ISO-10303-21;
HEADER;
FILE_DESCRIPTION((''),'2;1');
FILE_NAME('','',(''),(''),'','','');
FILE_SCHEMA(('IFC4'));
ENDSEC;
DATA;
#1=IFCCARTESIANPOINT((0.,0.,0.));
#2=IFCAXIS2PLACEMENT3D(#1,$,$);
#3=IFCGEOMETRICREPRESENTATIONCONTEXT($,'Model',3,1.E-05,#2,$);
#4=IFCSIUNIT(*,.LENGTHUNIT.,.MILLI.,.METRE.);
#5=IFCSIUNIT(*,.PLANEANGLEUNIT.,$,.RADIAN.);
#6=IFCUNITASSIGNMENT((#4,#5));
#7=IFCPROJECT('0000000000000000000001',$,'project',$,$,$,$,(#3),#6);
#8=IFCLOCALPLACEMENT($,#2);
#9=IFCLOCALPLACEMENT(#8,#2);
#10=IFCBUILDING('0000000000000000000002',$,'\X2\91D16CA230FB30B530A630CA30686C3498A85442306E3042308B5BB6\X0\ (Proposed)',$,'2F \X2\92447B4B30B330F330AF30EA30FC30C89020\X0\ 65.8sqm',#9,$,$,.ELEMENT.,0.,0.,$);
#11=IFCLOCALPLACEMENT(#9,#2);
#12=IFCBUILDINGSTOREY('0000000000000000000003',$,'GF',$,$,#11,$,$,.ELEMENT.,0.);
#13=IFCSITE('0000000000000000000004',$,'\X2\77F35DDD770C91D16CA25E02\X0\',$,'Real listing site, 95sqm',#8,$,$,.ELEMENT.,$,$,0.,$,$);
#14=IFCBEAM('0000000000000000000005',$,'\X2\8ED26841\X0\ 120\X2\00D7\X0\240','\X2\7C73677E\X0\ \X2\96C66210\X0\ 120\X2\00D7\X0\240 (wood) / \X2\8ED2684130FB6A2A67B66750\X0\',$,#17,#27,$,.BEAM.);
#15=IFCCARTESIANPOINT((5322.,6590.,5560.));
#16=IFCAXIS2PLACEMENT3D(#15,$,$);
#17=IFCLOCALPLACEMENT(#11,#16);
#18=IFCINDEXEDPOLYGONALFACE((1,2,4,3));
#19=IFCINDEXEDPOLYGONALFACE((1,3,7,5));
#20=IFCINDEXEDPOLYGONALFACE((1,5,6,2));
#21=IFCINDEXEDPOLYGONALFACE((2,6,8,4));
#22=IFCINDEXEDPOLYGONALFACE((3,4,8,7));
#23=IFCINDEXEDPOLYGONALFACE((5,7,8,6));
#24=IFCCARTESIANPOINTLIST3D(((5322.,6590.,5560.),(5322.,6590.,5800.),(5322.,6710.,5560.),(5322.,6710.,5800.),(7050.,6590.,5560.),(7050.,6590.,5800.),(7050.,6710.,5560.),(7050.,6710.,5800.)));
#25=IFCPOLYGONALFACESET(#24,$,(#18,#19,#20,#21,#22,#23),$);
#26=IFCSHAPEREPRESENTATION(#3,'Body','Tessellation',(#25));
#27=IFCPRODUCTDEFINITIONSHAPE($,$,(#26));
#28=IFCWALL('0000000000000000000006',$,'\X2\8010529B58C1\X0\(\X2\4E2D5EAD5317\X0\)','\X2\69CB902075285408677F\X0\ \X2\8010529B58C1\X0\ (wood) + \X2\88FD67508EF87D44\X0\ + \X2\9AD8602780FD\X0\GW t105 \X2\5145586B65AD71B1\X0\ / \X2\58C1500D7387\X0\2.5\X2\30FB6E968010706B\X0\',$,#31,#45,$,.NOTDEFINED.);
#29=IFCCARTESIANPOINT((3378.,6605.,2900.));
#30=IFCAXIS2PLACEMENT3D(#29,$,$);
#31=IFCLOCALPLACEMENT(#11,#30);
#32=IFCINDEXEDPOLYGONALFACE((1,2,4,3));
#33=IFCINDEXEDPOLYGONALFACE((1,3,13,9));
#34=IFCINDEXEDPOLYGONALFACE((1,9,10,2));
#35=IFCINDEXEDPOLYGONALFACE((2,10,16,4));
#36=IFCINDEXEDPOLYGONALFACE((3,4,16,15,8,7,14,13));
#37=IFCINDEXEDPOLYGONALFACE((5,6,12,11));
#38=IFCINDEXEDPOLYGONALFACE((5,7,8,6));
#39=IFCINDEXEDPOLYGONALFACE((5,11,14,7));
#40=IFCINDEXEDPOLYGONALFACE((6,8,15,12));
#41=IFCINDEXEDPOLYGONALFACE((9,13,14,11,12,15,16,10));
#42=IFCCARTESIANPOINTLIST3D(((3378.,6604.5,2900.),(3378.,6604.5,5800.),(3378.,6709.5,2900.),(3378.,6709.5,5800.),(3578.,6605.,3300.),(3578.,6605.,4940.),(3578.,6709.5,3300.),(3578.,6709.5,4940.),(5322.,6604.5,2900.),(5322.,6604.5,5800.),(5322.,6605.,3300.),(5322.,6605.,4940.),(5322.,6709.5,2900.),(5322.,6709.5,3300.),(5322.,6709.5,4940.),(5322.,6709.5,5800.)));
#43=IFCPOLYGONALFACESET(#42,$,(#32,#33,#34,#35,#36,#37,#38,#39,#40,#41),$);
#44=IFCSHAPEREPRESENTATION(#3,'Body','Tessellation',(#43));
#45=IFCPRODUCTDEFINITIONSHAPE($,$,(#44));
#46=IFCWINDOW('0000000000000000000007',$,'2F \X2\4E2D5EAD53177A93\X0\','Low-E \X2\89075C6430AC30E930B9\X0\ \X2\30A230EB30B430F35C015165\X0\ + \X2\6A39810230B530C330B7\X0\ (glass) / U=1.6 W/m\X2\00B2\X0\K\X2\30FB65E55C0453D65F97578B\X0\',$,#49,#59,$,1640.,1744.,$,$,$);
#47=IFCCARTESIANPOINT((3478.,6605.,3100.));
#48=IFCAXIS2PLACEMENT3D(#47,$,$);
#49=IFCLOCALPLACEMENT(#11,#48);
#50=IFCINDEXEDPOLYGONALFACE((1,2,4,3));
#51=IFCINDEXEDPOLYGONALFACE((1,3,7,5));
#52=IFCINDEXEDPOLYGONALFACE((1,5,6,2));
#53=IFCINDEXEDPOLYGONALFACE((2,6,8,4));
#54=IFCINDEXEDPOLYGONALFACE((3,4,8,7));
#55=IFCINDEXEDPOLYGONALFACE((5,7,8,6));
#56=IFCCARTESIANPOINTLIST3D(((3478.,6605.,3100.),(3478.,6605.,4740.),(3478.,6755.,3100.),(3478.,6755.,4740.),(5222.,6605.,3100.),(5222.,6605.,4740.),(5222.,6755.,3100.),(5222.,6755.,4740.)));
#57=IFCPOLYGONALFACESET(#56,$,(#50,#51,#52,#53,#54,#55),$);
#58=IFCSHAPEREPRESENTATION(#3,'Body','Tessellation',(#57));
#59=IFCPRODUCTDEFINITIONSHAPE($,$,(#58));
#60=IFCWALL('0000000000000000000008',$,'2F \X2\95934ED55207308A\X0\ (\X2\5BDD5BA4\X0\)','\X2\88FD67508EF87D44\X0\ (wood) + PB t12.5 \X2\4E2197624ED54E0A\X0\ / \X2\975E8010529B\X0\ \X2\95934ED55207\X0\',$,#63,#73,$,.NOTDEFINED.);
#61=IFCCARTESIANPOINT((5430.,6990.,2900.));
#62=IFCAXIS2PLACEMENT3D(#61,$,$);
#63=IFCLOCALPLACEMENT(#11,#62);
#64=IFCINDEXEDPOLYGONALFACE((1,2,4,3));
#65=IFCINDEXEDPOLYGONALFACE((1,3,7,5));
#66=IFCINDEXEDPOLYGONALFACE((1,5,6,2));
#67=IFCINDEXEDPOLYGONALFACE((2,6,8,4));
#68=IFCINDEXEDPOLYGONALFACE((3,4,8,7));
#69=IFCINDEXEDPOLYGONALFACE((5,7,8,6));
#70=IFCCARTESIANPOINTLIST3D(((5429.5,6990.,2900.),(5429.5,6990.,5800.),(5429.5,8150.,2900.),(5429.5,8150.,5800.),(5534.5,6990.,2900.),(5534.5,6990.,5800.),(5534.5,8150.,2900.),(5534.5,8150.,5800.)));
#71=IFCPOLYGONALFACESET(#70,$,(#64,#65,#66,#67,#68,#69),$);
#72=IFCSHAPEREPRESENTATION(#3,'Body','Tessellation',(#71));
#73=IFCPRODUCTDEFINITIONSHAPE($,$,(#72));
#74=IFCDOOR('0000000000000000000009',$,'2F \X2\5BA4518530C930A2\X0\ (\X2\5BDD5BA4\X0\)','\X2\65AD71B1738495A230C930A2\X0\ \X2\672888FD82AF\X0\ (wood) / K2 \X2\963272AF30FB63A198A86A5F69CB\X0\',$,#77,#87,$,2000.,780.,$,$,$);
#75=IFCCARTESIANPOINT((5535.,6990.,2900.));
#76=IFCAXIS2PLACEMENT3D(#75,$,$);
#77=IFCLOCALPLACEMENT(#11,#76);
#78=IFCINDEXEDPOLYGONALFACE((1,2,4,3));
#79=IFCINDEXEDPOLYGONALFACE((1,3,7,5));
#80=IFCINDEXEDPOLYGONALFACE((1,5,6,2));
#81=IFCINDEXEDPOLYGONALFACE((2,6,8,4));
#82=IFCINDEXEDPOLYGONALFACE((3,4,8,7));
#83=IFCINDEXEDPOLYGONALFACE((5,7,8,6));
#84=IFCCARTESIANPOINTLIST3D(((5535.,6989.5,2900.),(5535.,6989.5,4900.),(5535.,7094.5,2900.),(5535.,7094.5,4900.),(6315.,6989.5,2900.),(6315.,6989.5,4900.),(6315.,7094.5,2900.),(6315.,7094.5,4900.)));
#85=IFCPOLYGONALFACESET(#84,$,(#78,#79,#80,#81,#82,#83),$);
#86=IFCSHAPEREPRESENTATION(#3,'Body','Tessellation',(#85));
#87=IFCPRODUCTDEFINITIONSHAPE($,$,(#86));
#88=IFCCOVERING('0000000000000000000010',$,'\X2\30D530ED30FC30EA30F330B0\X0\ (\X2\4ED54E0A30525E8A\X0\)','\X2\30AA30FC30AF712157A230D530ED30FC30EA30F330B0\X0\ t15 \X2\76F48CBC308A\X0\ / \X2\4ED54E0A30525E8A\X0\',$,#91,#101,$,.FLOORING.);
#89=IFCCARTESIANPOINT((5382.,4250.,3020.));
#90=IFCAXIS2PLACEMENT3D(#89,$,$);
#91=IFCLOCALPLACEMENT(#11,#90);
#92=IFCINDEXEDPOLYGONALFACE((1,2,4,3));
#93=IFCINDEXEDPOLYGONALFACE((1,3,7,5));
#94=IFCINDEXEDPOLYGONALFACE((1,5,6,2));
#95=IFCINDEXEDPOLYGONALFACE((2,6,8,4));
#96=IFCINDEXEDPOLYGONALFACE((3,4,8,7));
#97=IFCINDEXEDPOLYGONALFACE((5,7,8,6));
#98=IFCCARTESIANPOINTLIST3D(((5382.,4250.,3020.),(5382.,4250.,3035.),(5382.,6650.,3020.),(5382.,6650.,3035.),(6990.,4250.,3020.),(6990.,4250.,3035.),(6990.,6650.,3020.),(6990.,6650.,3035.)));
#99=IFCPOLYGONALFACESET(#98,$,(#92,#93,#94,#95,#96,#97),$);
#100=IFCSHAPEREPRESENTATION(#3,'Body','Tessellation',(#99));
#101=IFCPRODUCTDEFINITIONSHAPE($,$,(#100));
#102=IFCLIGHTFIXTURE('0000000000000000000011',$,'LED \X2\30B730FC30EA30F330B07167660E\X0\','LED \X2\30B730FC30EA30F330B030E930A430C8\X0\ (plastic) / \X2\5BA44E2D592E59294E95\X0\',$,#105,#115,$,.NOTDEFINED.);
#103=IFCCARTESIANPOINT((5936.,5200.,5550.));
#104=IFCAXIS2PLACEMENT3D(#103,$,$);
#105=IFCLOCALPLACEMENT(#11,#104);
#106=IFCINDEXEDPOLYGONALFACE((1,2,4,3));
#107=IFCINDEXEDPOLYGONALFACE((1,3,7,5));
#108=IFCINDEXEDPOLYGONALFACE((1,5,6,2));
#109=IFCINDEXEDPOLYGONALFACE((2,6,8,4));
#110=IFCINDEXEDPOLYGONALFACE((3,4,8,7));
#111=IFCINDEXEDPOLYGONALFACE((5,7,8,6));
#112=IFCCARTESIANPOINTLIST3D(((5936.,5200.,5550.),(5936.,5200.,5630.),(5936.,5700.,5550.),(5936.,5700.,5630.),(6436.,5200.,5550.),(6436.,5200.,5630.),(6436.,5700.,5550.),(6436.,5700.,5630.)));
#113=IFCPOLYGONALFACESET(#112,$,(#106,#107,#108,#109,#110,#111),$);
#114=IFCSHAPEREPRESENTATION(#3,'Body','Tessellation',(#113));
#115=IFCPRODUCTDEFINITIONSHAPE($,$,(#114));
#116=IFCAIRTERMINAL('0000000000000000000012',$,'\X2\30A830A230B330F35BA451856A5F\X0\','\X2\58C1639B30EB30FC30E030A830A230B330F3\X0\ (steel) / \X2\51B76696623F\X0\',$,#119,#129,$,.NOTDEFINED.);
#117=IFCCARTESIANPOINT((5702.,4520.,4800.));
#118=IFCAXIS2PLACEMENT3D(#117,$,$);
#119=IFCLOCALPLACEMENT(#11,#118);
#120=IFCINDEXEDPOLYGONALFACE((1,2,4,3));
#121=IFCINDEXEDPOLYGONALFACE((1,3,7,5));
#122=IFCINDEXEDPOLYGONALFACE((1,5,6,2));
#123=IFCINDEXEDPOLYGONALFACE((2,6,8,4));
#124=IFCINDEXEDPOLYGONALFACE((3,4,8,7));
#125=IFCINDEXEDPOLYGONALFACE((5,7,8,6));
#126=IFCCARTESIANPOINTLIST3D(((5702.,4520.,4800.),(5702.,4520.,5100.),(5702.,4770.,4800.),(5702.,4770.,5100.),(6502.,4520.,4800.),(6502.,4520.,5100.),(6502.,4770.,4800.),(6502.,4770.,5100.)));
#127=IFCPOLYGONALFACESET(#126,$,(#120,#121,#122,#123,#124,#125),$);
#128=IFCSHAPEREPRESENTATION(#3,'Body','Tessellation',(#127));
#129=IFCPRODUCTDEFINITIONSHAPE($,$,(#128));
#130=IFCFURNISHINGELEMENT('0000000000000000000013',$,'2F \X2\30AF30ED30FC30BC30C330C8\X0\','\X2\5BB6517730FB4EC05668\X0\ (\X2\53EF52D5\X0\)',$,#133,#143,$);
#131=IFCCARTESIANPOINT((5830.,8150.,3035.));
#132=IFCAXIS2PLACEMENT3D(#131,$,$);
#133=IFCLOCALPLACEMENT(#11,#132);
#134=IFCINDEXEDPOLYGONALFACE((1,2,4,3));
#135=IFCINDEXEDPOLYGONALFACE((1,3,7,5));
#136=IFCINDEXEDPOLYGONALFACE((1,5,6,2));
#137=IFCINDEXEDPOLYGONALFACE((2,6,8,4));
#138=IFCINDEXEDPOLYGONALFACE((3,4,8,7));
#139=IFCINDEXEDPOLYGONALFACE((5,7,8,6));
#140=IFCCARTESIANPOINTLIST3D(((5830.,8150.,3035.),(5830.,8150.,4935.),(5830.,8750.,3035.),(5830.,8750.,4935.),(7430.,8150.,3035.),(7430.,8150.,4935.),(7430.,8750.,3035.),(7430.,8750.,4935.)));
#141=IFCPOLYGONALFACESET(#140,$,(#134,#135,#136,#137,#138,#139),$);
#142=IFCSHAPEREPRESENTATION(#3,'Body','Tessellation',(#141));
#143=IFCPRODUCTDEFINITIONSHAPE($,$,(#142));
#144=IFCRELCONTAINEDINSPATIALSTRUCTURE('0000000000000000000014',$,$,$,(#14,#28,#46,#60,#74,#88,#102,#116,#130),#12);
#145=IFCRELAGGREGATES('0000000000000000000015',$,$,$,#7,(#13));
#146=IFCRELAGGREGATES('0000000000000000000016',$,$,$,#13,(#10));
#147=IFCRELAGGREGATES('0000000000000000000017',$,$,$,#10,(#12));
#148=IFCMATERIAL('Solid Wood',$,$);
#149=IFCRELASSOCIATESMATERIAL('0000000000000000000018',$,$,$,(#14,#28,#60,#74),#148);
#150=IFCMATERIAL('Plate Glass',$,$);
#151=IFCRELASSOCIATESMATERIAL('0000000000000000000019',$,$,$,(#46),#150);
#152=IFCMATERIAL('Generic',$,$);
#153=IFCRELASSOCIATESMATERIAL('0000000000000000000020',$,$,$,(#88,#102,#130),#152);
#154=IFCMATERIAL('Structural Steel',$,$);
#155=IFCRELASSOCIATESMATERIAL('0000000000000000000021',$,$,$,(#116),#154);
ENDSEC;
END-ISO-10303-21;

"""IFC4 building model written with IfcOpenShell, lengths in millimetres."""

from ifc_helpers import new_model, si_unit, frame, frame_2d, origin, place, context, project, spatial, rectangle, extrude, material, element, fill, save


model = new_model("IFC4")

# Units and contexts
model_context = context("Model", 3, precision=1e-05, world=origin())
ifc_project = project(units=[si_unit("LENGTHUNIT", "METRE", prefix="MILLI"), si_unit("PLANEANGLEUNIT", "RADIAN")], contexts=[model_context])

# Site, building, storey
site_placement = place(None, origin())
site = spatial("IfcSite", under=ifc_project, at=site_placement, Name="石川県金沢市", ObjectType="Real listing site, 95sqm", CompositionType="ELEMENT", RefElevation=0.0)
building_placement = place(site_placement, origin())
building = spatial("IfcBuilding", under=site, at=building_placement, Name="金沢・サウナと水風呂のある家 (Proposed)", ObjectType="2F 鉄筋コンクリート造 65.8sqm", CompositionType="ELEMENT", ElevationOfRefHeight=0.0, ElevationOfTerrain=0.0)
storey_placement = place(building_placement, origin())
storey = spatial("IfcBuildingStorey", under=building, at=storey_placement, Name="GF", CompositionType="ELEMENT", Elevation=0.0)

# Shared definitions
ifc_material_1 = material(Name="Solid Wood")

# Beam
beam_1_placement = place(storey_placement, frame((5322.0, 6590.0, 5560.0)))
element("IfcBeam", 1, at=beam_1_placement, inside=storey, material=ifc_material_1, Name="軒桁 120×240", Description="米松 集成 120×240 (wood) / 軒桁・横架材", PredefinedType="BEAM", context=model_context, shape_type="SweptSolid", body=[
    extrude(rectangle(XDim=1728.0, YDim=120.0, at=frame_2d((864.0, 60.0))), frame((5322.0, 6590.0, 5560.0)), (0.0, 0.0, 1.0), 240.0),
])

# Wall, opening, window
wall_1_placement = place(storey_placement, frame((3378.0, 6605.0, 2900.0)))
wall_1 = element("IfcWall", 2, at=wall_1_placement, inside=storey, material=ifc_material_1, Name="耐力壁(中庭北)", Description="構造用合板 耐力壁 (wood) + 製材軸組 + 高性能GW t105 充填断熱 / 壁倍率2.5・準耐火", PredefinedType="NOTDEFINED", context=model_context, shape_type="SweptSolid", body=[
    extrude(rectangle(XDim=1944.0, YDim=105.0, at=frame_2d((972.0, 52.0))), frame((3378.0, 6605.0, 2900.0)), (0.0, 0.0, 1.0), 2900.0),
])
opening_placement = place(storey_placement, frame((3478.0, 6605.0, 3100.0)))
opening = element("IfcOpeningElement", 3, at=opening_placement, cuts=wall_1, PredefinedType="NOTDEFINED", context=model_context, shape_type="SweptSolid", body=[
    extrude(rectangle(XDim=1744.0, YDim=150.0, at=frame_2d((872.0, 75.0))), frame((3478.0, 6605.0, 3100.0)), (0.0, 0.0, 1.0), 1640.0),
])
ifc_material_2 = material(Name="Plate Glass")
window_placement = place(storey_placement, frame((3478.0, 6605.0, 3100.0)))
window = element("IfcWindow", 4, at=window_placement, inside=storey, material=ifc_material_2, Name="2F 中庭北窓", Description="Low-E 複層ガラス アルゴン封入 + 樹脂サッシ (glass) / U=1.6 W/m²K・日射取得型", OverallHeight=1640.0, OverallWidth=1744.0, context=model_context, shape_type="SweptSolid", body=[
    extrude(rectangle(XDim=1744.0, YDim=150.0, at=frame_2d((872.0, 75.0))), frame((3478.0, 6605.0, 3100.0)), (0.0, 0.0, 1.0), 1640.0),
])
fill(opening, window)

# Wall
wall_2_placement = place(storey_placement, frame((5430.0, 6990.0, 2900.0)))
element("IfcWall", 5, at=wall_2_placement, inside=storey, material=ifc_material_1, Name="2F 間仕切り (寝室)", Description="製材軸組 (wood) + PB t12.5 両面仕上 / 非耐力 間仕切", PredefinedType="NOTDEFINED", context=model_context, shape_type="SweptSolid", body=[
    extrude(rectangle(XDim=105.0, YDim=1160.0, at=frame_2d((52.0, 580.0))), frame((5430.0, 6990.0, 2900.0)), (0.0, 0.0, 1.0), 2900.0),
])

# Door
door_placement = place(storey_placement, frame((5535.0, 6990.0, 2900.0)))
element("IfcDoor", 6, at=door_placement, inside=storey, material=ifc_material_1, Name="2F 室内ドア (寝室)", Description="断熱玄関ドア 木製芯 (wood) / K2 防犯・採風機構", OverallHeight=2000.0, OverallWidth=780.0, context=model_context, shape_type="SweptSolid", body=[
    extrude(rectangle(XDim=780.0, YDim=105.0, at=frame_2d((390.0, 52.0))), frame((5535.0, 6990.0, 2900.0)), (0.0, 0.0, 1.0), 2000.0),
])

# Covering
ifc_material_3 = material(Name="Generic")
covering_placement = place(storey_placement, frame((5382.0, 4250.0, 3020.0)))
element("IfcCovering", 7, at=covering_placement, inside=storey, material=ifc_material_3, Name="フローリング (仕上げ床)", Description="オーク無垢フローリング t15 直貼り / 仕上げ床", PredefinedType="FLOORING", context=model_context, shape_type="SweptSolid", body=[
    extrude(rectangle(XDim=1608.0, YDim=2400.0, at=frame_2d((804.0, 1200.0))), frame((5382.0, 4250.0, 3020.0)), (0.0, 0.0, 1.0), 15.0),
])

# Light fixture
light_fixture_placement = place(storey_placement, frame((5936.0, 5200.0, 5550.0)))
element("IfcLightFixture", 8, at=light_fixture_placement, inside=storey, material=ifc_material_3, Name="LED シーリング照明", Description="LED シーリングライト (plastic) / 室中央天井", PredefinedType="NOTDEFINED", context=model_context, shape_type="SweptSolid", body=[
    extrude(rectangle(XDim=500.0, YDim=500.0, at=frame_2d((250.0, 250.0))), frame((5936.0, 5200.0, 5550.0)), (0.0, 0.0, 1.0), 80.0),
])

# Air terminal
ifc_material_4 = material(Name="Structural Steel")
air_terminal_placement = place(storey_placement, frame((5702.0, 4520.0, 4800.0)))
element("IfcAirTerminal", 9, at=air_terminal_placement, inside=storey, material=ifc_material_4, Name="エアコン室内機", Description="壁掛ルームエアコン (steel) / 冷暖房", PredefinedType="NOTDEFINED", context=model_context, shape_type="SweptSolid", body=[
    extrude(rectangle(XDim=800.0, YDim=250.0, at=frame_2d((400.0, 125.0))), frame((5702.0, 4520.0, 4800.0)), (0.0, 0.0, 1.0), 300.0),
])

# Furnishing element
furnishing_placement = place(storey_placement, frame((5830.0, 8150.0, 3035.0)))
element("IfcFurnishingElement", 10, at=furnishing_placement, inside=storey, material=ifc_material_3, Name="2F クローゼット", Description="家具・什器 (可動)", context=model_context, shape_type="SweptSolid", body=[
    extrude(rectangle(XDim=1600.0, YDim=600.0, at=frame_2d((800.0, 300.0))), frame((5830.0, 8150.0, 3035.0)), (0.0, 0.0, 1.0), 1900.0),
])

save(model, "model.ifc")
